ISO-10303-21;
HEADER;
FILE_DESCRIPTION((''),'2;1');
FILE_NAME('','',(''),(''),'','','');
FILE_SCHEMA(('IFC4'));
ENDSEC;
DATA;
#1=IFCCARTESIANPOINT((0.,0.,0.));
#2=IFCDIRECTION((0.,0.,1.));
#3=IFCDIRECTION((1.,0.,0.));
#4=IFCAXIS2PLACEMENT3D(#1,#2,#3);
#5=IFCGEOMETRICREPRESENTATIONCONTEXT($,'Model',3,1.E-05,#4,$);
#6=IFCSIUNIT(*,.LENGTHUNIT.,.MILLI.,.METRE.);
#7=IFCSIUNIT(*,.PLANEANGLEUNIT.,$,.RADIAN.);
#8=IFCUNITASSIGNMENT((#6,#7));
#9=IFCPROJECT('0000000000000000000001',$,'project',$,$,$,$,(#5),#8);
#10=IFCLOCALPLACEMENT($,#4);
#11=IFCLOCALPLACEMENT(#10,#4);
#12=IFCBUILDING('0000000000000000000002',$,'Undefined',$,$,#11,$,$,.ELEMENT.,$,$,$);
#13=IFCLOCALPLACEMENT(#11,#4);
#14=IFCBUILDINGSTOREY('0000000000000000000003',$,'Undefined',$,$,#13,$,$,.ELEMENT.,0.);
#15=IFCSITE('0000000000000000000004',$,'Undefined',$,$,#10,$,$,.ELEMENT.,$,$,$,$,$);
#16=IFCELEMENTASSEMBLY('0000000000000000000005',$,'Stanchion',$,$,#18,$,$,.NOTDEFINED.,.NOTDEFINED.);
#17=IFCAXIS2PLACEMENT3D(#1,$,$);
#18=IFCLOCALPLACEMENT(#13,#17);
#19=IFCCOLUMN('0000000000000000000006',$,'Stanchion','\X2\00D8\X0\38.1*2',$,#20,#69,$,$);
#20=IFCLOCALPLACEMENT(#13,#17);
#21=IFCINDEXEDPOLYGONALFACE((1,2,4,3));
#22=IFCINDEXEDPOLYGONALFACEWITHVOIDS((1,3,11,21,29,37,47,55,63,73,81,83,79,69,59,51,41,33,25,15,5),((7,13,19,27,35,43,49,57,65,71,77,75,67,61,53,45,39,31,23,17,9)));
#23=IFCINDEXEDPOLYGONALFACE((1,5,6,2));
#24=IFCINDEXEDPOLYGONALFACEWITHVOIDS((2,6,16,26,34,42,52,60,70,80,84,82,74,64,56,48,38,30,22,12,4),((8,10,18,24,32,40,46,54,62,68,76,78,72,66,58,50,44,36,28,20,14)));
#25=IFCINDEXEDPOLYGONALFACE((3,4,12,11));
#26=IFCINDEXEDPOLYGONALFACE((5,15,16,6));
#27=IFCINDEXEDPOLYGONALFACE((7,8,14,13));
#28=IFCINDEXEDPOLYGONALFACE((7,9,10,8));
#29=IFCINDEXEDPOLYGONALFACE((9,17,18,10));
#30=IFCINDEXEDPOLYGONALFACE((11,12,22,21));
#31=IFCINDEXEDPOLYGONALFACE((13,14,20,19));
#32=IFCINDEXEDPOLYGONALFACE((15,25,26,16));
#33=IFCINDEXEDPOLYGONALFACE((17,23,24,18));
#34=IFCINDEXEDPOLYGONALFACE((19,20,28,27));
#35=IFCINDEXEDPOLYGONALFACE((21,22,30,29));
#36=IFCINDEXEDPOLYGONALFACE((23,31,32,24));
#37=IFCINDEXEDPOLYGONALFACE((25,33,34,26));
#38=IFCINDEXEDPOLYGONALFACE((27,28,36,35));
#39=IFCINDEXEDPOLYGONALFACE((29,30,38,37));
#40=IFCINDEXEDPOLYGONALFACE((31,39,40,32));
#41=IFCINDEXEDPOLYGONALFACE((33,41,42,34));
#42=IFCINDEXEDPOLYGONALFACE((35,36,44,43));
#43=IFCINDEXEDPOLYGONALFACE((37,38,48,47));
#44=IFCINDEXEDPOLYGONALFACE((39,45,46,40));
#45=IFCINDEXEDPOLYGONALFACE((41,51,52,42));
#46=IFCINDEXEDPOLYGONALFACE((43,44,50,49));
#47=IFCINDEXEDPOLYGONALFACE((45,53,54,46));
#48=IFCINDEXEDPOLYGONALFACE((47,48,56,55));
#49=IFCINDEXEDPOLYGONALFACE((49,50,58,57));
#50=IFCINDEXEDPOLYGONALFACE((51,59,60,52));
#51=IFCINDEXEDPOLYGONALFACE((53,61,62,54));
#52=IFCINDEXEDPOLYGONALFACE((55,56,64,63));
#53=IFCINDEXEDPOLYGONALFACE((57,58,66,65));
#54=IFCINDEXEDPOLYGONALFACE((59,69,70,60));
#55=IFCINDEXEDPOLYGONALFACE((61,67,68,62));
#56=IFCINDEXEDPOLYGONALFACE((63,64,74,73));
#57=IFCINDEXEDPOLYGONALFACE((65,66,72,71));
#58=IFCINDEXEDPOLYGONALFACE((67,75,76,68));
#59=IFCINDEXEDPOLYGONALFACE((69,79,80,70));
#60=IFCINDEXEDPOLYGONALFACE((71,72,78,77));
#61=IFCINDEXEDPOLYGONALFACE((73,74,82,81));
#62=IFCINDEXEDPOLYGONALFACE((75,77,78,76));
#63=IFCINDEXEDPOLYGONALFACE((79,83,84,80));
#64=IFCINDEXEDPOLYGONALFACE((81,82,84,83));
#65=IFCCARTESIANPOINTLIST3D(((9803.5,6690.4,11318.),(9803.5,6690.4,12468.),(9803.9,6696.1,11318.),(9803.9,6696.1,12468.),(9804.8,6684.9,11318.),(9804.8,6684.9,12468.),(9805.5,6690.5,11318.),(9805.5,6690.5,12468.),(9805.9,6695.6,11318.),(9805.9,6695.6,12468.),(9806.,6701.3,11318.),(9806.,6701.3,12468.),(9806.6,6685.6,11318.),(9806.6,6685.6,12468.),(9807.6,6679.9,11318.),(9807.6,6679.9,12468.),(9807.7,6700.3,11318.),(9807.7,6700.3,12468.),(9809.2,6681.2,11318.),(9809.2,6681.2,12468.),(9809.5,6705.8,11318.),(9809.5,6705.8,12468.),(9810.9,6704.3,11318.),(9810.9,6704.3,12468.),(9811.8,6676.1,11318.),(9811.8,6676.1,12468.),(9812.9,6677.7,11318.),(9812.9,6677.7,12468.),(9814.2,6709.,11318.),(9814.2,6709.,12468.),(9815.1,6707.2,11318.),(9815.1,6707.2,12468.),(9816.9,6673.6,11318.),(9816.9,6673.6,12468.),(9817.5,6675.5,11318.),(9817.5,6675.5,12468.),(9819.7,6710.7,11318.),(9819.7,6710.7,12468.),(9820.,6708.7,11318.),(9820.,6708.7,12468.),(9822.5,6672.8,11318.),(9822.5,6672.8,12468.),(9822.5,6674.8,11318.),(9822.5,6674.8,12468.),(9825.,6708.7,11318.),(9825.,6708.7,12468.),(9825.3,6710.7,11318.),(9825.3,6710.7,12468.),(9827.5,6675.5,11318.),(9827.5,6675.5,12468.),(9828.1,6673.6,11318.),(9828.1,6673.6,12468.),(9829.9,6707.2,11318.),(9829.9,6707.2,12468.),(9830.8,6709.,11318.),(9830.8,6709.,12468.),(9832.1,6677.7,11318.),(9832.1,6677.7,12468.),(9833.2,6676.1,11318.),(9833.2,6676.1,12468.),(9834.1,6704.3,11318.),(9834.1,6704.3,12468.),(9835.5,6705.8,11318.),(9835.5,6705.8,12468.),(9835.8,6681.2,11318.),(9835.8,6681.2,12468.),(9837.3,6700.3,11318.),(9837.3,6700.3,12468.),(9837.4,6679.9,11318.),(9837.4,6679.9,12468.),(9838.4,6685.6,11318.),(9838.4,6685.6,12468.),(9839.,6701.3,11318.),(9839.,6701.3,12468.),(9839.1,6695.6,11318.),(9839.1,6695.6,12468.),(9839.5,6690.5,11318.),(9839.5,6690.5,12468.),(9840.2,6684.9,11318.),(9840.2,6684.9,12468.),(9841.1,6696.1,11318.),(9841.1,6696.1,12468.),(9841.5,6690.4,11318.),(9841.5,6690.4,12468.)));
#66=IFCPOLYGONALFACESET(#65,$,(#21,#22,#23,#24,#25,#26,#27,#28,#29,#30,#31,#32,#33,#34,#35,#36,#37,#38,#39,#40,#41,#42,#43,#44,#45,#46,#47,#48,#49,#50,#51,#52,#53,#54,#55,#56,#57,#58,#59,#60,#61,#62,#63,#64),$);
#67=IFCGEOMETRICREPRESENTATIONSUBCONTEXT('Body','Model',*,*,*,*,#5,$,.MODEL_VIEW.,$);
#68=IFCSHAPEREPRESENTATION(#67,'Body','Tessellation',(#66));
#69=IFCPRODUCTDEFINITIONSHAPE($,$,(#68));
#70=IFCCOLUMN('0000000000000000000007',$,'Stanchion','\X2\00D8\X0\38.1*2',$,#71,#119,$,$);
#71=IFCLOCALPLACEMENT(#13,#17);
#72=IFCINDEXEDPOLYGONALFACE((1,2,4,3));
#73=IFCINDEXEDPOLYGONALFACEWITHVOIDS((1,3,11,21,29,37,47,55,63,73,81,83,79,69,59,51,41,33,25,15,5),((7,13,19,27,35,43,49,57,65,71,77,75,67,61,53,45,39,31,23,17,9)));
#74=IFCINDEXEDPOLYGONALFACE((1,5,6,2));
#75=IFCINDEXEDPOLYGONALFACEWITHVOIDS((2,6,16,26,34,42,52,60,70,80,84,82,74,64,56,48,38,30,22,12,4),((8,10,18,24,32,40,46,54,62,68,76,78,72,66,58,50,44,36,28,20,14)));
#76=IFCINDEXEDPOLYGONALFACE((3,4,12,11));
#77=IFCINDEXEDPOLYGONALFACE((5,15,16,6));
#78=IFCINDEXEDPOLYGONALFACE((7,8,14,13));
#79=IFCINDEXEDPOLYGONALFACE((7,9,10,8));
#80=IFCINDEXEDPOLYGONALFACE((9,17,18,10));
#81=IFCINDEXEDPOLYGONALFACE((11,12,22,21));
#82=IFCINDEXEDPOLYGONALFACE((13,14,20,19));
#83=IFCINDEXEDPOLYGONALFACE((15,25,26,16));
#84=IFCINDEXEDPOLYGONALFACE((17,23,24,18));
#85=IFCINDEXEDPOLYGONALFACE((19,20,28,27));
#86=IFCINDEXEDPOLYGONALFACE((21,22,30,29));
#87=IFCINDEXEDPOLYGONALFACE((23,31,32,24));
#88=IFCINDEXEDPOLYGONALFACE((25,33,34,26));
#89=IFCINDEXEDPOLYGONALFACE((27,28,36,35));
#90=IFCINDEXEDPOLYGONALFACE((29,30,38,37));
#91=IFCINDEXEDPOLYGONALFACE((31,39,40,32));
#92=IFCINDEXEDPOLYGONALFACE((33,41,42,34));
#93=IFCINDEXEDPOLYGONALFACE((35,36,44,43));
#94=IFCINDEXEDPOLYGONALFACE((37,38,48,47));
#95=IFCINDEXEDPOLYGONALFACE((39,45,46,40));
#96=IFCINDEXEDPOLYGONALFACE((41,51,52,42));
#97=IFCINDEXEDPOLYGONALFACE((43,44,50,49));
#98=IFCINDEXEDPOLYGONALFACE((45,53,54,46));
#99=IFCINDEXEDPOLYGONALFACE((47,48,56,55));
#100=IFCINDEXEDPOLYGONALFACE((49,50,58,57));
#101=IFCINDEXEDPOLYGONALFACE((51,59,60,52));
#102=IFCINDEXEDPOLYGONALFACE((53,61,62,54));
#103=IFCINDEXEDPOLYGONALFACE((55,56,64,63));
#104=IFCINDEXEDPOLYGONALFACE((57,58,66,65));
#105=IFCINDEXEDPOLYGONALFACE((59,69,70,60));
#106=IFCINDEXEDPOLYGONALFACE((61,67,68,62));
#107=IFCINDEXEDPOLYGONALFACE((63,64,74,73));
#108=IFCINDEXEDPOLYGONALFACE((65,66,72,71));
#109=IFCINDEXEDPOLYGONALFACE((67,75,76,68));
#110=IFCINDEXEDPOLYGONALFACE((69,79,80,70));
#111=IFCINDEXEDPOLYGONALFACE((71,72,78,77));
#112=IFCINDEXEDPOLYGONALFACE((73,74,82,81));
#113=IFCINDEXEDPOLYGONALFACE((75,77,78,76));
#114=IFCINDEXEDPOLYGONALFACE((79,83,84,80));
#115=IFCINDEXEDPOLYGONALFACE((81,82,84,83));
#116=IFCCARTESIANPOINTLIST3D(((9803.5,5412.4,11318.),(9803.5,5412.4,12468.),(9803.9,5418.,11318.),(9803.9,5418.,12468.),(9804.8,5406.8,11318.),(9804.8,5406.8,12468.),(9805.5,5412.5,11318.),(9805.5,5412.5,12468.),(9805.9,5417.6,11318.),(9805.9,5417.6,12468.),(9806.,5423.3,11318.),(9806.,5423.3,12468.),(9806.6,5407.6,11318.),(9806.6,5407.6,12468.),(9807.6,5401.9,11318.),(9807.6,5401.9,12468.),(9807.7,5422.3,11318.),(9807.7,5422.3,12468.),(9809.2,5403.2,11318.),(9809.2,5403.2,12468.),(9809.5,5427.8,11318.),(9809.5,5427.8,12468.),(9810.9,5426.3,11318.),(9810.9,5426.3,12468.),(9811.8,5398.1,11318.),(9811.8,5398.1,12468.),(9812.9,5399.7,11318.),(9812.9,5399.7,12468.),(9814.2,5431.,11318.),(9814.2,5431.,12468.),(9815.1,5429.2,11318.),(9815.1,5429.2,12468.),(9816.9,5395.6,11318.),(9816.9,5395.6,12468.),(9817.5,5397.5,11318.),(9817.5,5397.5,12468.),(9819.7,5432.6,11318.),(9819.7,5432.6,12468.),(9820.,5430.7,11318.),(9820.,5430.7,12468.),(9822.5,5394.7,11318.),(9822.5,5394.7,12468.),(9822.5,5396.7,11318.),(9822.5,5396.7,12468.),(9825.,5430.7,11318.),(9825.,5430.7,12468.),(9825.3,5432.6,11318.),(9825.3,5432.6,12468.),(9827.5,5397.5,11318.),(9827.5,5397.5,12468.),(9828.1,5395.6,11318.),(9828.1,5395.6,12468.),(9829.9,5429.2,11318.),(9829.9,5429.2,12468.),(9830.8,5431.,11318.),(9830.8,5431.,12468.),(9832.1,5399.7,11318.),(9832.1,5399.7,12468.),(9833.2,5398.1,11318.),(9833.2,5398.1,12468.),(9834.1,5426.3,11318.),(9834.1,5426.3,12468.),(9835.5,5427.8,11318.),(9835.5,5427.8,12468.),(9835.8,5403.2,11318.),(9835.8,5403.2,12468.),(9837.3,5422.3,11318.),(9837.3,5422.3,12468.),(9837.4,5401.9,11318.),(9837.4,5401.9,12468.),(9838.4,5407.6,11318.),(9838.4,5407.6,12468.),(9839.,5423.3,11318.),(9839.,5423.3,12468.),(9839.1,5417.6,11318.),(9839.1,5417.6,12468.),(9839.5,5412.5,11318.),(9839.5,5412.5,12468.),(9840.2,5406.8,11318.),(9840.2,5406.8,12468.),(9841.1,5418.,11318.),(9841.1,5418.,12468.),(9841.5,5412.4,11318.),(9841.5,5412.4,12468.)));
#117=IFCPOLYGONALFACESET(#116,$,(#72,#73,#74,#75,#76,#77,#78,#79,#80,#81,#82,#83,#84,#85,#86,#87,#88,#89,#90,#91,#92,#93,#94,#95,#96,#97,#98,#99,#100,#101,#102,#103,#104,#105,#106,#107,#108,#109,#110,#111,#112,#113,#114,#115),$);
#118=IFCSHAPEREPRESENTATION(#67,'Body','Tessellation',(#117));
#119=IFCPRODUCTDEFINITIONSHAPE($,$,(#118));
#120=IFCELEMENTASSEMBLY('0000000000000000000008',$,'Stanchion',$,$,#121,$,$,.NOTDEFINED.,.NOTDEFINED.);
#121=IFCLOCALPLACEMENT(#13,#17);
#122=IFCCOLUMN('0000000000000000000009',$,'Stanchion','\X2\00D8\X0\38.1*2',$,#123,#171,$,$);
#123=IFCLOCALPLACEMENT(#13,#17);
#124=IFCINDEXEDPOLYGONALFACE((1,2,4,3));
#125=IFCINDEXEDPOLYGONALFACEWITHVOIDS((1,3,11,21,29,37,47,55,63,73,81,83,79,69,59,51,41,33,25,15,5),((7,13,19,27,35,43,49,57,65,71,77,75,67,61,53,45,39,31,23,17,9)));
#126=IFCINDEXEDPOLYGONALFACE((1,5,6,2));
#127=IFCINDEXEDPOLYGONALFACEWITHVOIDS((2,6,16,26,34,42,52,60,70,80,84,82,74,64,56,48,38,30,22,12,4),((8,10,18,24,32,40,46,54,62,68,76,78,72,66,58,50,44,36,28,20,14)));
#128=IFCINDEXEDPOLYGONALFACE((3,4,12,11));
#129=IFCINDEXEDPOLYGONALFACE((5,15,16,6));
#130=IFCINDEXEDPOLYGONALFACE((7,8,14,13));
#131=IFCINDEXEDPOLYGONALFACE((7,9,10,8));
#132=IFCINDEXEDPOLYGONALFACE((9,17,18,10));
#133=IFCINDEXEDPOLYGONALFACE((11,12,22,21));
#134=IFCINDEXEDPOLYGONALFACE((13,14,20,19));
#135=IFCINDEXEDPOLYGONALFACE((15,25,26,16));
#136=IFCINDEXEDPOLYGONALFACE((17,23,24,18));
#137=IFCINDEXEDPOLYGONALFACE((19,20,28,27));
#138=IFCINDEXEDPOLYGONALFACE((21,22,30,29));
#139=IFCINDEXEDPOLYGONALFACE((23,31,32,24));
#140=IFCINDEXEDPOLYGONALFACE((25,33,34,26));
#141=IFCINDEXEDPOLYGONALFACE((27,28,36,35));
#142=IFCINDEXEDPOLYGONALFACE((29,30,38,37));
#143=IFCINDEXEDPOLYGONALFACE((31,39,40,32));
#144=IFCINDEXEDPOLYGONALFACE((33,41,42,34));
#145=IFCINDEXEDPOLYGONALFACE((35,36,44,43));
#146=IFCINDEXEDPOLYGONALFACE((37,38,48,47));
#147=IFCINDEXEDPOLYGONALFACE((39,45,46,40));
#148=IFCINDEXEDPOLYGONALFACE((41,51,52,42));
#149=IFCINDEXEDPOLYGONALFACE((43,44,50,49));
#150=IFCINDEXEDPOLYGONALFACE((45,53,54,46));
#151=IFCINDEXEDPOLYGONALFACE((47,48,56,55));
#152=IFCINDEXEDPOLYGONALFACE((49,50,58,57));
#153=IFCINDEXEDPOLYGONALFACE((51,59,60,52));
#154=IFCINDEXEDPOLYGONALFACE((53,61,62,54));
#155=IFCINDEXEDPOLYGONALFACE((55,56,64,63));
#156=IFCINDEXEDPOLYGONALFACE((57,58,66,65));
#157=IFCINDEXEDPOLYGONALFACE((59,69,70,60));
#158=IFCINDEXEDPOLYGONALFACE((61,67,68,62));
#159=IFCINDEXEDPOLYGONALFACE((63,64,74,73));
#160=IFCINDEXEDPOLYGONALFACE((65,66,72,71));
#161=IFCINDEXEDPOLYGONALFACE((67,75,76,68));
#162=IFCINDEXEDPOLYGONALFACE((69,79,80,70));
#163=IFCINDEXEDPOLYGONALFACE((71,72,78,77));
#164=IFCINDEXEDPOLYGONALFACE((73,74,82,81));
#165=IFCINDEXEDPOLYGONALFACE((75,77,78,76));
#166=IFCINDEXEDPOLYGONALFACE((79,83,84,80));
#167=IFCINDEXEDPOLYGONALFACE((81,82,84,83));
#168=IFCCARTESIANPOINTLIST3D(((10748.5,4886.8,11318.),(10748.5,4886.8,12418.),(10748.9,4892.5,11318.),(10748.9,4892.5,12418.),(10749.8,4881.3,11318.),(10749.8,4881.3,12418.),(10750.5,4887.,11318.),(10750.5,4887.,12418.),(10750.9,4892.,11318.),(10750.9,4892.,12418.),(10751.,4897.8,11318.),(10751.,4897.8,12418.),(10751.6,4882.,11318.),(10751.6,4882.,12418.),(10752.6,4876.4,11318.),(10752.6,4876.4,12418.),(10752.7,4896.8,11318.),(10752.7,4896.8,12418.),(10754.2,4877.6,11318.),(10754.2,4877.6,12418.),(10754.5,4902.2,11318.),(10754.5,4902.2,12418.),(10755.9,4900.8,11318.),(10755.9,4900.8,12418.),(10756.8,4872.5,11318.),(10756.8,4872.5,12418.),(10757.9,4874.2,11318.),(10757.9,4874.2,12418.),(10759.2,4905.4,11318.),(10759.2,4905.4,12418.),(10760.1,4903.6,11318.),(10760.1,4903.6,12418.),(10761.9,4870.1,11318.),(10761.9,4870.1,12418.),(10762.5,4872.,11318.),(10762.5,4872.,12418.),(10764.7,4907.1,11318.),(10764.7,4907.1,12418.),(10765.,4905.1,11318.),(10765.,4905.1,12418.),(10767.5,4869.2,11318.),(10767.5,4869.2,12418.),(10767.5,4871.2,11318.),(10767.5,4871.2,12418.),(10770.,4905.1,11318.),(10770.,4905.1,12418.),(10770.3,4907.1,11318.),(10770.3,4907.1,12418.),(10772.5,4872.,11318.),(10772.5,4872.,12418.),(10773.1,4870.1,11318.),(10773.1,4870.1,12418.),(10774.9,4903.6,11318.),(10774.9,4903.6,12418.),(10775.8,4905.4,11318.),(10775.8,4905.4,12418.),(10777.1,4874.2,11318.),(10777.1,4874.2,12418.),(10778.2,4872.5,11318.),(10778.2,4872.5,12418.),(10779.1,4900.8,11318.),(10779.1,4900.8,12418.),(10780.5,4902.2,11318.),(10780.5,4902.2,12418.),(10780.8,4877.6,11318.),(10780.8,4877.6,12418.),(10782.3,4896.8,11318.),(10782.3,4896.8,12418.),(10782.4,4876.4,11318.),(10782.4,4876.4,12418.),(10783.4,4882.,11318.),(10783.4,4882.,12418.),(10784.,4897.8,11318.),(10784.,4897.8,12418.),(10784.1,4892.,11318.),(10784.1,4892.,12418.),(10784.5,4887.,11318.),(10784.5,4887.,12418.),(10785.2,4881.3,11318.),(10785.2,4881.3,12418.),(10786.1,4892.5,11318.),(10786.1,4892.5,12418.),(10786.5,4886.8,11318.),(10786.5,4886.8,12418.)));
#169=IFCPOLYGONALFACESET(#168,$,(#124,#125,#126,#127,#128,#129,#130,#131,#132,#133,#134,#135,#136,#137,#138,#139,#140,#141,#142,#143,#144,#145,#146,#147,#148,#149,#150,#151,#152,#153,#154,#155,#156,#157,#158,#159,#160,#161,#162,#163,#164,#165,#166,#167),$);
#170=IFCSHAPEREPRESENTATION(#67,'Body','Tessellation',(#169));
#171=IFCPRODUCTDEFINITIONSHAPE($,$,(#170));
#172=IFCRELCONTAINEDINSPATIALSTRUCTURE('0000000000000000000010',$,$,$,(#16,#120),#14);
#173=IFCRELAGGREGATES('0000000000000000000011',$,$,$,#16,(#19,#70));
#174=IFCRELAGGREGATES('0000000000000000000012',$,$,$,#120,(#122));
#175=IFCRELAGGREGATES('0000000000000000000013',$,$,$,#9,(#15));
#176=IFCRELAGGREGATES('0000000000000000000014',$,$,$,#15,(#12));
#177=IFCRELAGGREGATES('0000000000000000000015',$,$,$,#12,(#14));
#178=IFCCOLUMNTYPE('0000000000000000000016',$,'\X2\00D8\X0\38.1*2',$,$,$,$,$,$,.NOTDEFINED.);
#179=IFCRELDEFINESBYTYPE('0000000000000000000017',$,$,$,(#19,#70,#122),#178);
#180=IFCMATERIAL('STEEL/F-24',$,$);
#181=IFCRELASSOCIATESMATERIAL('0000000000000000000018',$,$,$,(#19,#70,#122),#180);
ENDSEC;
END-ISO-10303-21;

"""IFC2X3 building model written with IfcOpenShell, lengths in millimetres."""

from ifc_helpers import new_model, si_unit, frame, origin_with_axes, origin_2d_with_axis, place, context, subcontext, project, spatial, hollow_circle, extrude, material, type_object, element, aggregate, save


model = new_model("IFC2X3")

# Units and contexts
model_context = context("Model", 3, precision=1e-05, world=origin_with_axes())
body_context = subcontext(model_context, "Body", "Model", "MODEL_VIEW")
ifc_project = project(units=[si_unit("LENGTHUNIT", "METRE", prefix="MILLI"), si_unit("PLANEANGLEUNIT", "RADIAN")], contexts=[model_context])

# Site, building, storey
site_placement = place(None, origin_with_axes())
site = spatial("IfcSite", under=ifc_project, at=site_placement, Name="Undefined", CompositionType="ELEMENT")
building_placement = place(site_placement, origin_with_axes())
building = spatial("IfcBuilding", under=site, at=building_placement, Name="Undefined", CompositionType="ELEMENT")
storey_placement = place(building_placement, origin_with_axes())
storey = spatial("IfcBuildingStorey", under=building, at=storey_placement, Name="Undefined", CompositionType="ELEMENT", Elevation=0.0)

# Element assemblies, columns
assembly_1_placement = place(storey_placement, origin_with_axes())
assembly_1 = element("IfcElementAssembly", 1, at=assembly_1_placement, inside=storey, Name="Stanchion", AssemblyPlace="NOTDEFINED", PredefinedType="NOTDEFINED")
ifc_material_1 = material(Name="STEEL/F-24")
column_type = type_object("IfcColumnType", Name="Ø38.1*2", PredefinedType="NOTDEFINED")
column_1_placement = place(assembly_1_placement, frame((9822.5, 6691.8, 11318.0), z_axis=(0.0, 0.0, 1.0), x_axis=(-1.0, 0.0, 0.0)))
column_1 = element("IfcColumn", 2, at=column_1_placement, type_object=column_type, material=ifc_material_1, Name="Stanchion", Description="Ø38.1*2", context=body_context, shape_type="SweptSolid", body=[
    extrude(hollow_circle(Radius=19.1, WallThickness=2.0, at=origin_2d_with_axis()), frame((0.0, 0.0, 1150.0), z_axis=(0.0, 0.0, -1.0), x_axis=(0.0, 1.0, 0.0)), (0.0, 0.0, 1.0), 1150.0),
])
column_2_placement = place(assembly_1_placement, frame((9822.5, 5413.8, 11318.0), z_axis=(0.0, 0.0, 1.0), x_axis=(-1.0, 0.0, 0.0)))
column_2 = element("IfcColumn", 3, at=column_2_placement, type_object=column_type, material=ifc_material_1, Name="Stanchion", Description="Ø38.1*2", context=body_context, shape_type="SweptSolid", body=[
    extrude(hollow_circle(Radius=19.1, WallThickness=2.0, at=origin_2d_with_axis()), frame((0.0, 0.0, 1150.0), z_axis=(0.0, 0.0, -1.0), x_axis=(0.0, 1.0, 0.0)), (0.0, 0.0, 1.0), 1150.0),
])
assembly_2_placement = place(storey_placement, origin_with_axes())
assembly_2 = element("IfcElementAssembly", 4, at=assembly_2_placement, inside=storey, Name="Stanchion", AssemblyPlace="NOTDEFINED", PredefinedType="NOTDEFINED")
column_3_placement = place(assembly_2_placement, frame((10767.5, 4888.3, 11318.0), z_axis=(0.0, 0.0, 1.0), x_axis=(-1.0, 0.0, 0.0)))
column_3 = element("IfcColumn", 5, at=column_3_placement, type_object=column_type, material=ifc_material_1, Name="Stanchion", Description="Ø38.1*2", context=body_context, shape_type="SweptSolid", body=[
    extrude(hollow_circle(Radius=19.1, WallThickness=2.0, at=origin_2d_with_axis()), frame((0.0, 0.0, 1100.0), z_axis=(0.0, 0.0, -1.0), x_axis=(0.0, 1.0, 0.0)), (0.0, 0.0, 1.0), 1100.0),
])

aggregate(assembly_1, [column_1, column_2])
aggregate(assembly_2, [column_3])

save(model, "model.ifc")
